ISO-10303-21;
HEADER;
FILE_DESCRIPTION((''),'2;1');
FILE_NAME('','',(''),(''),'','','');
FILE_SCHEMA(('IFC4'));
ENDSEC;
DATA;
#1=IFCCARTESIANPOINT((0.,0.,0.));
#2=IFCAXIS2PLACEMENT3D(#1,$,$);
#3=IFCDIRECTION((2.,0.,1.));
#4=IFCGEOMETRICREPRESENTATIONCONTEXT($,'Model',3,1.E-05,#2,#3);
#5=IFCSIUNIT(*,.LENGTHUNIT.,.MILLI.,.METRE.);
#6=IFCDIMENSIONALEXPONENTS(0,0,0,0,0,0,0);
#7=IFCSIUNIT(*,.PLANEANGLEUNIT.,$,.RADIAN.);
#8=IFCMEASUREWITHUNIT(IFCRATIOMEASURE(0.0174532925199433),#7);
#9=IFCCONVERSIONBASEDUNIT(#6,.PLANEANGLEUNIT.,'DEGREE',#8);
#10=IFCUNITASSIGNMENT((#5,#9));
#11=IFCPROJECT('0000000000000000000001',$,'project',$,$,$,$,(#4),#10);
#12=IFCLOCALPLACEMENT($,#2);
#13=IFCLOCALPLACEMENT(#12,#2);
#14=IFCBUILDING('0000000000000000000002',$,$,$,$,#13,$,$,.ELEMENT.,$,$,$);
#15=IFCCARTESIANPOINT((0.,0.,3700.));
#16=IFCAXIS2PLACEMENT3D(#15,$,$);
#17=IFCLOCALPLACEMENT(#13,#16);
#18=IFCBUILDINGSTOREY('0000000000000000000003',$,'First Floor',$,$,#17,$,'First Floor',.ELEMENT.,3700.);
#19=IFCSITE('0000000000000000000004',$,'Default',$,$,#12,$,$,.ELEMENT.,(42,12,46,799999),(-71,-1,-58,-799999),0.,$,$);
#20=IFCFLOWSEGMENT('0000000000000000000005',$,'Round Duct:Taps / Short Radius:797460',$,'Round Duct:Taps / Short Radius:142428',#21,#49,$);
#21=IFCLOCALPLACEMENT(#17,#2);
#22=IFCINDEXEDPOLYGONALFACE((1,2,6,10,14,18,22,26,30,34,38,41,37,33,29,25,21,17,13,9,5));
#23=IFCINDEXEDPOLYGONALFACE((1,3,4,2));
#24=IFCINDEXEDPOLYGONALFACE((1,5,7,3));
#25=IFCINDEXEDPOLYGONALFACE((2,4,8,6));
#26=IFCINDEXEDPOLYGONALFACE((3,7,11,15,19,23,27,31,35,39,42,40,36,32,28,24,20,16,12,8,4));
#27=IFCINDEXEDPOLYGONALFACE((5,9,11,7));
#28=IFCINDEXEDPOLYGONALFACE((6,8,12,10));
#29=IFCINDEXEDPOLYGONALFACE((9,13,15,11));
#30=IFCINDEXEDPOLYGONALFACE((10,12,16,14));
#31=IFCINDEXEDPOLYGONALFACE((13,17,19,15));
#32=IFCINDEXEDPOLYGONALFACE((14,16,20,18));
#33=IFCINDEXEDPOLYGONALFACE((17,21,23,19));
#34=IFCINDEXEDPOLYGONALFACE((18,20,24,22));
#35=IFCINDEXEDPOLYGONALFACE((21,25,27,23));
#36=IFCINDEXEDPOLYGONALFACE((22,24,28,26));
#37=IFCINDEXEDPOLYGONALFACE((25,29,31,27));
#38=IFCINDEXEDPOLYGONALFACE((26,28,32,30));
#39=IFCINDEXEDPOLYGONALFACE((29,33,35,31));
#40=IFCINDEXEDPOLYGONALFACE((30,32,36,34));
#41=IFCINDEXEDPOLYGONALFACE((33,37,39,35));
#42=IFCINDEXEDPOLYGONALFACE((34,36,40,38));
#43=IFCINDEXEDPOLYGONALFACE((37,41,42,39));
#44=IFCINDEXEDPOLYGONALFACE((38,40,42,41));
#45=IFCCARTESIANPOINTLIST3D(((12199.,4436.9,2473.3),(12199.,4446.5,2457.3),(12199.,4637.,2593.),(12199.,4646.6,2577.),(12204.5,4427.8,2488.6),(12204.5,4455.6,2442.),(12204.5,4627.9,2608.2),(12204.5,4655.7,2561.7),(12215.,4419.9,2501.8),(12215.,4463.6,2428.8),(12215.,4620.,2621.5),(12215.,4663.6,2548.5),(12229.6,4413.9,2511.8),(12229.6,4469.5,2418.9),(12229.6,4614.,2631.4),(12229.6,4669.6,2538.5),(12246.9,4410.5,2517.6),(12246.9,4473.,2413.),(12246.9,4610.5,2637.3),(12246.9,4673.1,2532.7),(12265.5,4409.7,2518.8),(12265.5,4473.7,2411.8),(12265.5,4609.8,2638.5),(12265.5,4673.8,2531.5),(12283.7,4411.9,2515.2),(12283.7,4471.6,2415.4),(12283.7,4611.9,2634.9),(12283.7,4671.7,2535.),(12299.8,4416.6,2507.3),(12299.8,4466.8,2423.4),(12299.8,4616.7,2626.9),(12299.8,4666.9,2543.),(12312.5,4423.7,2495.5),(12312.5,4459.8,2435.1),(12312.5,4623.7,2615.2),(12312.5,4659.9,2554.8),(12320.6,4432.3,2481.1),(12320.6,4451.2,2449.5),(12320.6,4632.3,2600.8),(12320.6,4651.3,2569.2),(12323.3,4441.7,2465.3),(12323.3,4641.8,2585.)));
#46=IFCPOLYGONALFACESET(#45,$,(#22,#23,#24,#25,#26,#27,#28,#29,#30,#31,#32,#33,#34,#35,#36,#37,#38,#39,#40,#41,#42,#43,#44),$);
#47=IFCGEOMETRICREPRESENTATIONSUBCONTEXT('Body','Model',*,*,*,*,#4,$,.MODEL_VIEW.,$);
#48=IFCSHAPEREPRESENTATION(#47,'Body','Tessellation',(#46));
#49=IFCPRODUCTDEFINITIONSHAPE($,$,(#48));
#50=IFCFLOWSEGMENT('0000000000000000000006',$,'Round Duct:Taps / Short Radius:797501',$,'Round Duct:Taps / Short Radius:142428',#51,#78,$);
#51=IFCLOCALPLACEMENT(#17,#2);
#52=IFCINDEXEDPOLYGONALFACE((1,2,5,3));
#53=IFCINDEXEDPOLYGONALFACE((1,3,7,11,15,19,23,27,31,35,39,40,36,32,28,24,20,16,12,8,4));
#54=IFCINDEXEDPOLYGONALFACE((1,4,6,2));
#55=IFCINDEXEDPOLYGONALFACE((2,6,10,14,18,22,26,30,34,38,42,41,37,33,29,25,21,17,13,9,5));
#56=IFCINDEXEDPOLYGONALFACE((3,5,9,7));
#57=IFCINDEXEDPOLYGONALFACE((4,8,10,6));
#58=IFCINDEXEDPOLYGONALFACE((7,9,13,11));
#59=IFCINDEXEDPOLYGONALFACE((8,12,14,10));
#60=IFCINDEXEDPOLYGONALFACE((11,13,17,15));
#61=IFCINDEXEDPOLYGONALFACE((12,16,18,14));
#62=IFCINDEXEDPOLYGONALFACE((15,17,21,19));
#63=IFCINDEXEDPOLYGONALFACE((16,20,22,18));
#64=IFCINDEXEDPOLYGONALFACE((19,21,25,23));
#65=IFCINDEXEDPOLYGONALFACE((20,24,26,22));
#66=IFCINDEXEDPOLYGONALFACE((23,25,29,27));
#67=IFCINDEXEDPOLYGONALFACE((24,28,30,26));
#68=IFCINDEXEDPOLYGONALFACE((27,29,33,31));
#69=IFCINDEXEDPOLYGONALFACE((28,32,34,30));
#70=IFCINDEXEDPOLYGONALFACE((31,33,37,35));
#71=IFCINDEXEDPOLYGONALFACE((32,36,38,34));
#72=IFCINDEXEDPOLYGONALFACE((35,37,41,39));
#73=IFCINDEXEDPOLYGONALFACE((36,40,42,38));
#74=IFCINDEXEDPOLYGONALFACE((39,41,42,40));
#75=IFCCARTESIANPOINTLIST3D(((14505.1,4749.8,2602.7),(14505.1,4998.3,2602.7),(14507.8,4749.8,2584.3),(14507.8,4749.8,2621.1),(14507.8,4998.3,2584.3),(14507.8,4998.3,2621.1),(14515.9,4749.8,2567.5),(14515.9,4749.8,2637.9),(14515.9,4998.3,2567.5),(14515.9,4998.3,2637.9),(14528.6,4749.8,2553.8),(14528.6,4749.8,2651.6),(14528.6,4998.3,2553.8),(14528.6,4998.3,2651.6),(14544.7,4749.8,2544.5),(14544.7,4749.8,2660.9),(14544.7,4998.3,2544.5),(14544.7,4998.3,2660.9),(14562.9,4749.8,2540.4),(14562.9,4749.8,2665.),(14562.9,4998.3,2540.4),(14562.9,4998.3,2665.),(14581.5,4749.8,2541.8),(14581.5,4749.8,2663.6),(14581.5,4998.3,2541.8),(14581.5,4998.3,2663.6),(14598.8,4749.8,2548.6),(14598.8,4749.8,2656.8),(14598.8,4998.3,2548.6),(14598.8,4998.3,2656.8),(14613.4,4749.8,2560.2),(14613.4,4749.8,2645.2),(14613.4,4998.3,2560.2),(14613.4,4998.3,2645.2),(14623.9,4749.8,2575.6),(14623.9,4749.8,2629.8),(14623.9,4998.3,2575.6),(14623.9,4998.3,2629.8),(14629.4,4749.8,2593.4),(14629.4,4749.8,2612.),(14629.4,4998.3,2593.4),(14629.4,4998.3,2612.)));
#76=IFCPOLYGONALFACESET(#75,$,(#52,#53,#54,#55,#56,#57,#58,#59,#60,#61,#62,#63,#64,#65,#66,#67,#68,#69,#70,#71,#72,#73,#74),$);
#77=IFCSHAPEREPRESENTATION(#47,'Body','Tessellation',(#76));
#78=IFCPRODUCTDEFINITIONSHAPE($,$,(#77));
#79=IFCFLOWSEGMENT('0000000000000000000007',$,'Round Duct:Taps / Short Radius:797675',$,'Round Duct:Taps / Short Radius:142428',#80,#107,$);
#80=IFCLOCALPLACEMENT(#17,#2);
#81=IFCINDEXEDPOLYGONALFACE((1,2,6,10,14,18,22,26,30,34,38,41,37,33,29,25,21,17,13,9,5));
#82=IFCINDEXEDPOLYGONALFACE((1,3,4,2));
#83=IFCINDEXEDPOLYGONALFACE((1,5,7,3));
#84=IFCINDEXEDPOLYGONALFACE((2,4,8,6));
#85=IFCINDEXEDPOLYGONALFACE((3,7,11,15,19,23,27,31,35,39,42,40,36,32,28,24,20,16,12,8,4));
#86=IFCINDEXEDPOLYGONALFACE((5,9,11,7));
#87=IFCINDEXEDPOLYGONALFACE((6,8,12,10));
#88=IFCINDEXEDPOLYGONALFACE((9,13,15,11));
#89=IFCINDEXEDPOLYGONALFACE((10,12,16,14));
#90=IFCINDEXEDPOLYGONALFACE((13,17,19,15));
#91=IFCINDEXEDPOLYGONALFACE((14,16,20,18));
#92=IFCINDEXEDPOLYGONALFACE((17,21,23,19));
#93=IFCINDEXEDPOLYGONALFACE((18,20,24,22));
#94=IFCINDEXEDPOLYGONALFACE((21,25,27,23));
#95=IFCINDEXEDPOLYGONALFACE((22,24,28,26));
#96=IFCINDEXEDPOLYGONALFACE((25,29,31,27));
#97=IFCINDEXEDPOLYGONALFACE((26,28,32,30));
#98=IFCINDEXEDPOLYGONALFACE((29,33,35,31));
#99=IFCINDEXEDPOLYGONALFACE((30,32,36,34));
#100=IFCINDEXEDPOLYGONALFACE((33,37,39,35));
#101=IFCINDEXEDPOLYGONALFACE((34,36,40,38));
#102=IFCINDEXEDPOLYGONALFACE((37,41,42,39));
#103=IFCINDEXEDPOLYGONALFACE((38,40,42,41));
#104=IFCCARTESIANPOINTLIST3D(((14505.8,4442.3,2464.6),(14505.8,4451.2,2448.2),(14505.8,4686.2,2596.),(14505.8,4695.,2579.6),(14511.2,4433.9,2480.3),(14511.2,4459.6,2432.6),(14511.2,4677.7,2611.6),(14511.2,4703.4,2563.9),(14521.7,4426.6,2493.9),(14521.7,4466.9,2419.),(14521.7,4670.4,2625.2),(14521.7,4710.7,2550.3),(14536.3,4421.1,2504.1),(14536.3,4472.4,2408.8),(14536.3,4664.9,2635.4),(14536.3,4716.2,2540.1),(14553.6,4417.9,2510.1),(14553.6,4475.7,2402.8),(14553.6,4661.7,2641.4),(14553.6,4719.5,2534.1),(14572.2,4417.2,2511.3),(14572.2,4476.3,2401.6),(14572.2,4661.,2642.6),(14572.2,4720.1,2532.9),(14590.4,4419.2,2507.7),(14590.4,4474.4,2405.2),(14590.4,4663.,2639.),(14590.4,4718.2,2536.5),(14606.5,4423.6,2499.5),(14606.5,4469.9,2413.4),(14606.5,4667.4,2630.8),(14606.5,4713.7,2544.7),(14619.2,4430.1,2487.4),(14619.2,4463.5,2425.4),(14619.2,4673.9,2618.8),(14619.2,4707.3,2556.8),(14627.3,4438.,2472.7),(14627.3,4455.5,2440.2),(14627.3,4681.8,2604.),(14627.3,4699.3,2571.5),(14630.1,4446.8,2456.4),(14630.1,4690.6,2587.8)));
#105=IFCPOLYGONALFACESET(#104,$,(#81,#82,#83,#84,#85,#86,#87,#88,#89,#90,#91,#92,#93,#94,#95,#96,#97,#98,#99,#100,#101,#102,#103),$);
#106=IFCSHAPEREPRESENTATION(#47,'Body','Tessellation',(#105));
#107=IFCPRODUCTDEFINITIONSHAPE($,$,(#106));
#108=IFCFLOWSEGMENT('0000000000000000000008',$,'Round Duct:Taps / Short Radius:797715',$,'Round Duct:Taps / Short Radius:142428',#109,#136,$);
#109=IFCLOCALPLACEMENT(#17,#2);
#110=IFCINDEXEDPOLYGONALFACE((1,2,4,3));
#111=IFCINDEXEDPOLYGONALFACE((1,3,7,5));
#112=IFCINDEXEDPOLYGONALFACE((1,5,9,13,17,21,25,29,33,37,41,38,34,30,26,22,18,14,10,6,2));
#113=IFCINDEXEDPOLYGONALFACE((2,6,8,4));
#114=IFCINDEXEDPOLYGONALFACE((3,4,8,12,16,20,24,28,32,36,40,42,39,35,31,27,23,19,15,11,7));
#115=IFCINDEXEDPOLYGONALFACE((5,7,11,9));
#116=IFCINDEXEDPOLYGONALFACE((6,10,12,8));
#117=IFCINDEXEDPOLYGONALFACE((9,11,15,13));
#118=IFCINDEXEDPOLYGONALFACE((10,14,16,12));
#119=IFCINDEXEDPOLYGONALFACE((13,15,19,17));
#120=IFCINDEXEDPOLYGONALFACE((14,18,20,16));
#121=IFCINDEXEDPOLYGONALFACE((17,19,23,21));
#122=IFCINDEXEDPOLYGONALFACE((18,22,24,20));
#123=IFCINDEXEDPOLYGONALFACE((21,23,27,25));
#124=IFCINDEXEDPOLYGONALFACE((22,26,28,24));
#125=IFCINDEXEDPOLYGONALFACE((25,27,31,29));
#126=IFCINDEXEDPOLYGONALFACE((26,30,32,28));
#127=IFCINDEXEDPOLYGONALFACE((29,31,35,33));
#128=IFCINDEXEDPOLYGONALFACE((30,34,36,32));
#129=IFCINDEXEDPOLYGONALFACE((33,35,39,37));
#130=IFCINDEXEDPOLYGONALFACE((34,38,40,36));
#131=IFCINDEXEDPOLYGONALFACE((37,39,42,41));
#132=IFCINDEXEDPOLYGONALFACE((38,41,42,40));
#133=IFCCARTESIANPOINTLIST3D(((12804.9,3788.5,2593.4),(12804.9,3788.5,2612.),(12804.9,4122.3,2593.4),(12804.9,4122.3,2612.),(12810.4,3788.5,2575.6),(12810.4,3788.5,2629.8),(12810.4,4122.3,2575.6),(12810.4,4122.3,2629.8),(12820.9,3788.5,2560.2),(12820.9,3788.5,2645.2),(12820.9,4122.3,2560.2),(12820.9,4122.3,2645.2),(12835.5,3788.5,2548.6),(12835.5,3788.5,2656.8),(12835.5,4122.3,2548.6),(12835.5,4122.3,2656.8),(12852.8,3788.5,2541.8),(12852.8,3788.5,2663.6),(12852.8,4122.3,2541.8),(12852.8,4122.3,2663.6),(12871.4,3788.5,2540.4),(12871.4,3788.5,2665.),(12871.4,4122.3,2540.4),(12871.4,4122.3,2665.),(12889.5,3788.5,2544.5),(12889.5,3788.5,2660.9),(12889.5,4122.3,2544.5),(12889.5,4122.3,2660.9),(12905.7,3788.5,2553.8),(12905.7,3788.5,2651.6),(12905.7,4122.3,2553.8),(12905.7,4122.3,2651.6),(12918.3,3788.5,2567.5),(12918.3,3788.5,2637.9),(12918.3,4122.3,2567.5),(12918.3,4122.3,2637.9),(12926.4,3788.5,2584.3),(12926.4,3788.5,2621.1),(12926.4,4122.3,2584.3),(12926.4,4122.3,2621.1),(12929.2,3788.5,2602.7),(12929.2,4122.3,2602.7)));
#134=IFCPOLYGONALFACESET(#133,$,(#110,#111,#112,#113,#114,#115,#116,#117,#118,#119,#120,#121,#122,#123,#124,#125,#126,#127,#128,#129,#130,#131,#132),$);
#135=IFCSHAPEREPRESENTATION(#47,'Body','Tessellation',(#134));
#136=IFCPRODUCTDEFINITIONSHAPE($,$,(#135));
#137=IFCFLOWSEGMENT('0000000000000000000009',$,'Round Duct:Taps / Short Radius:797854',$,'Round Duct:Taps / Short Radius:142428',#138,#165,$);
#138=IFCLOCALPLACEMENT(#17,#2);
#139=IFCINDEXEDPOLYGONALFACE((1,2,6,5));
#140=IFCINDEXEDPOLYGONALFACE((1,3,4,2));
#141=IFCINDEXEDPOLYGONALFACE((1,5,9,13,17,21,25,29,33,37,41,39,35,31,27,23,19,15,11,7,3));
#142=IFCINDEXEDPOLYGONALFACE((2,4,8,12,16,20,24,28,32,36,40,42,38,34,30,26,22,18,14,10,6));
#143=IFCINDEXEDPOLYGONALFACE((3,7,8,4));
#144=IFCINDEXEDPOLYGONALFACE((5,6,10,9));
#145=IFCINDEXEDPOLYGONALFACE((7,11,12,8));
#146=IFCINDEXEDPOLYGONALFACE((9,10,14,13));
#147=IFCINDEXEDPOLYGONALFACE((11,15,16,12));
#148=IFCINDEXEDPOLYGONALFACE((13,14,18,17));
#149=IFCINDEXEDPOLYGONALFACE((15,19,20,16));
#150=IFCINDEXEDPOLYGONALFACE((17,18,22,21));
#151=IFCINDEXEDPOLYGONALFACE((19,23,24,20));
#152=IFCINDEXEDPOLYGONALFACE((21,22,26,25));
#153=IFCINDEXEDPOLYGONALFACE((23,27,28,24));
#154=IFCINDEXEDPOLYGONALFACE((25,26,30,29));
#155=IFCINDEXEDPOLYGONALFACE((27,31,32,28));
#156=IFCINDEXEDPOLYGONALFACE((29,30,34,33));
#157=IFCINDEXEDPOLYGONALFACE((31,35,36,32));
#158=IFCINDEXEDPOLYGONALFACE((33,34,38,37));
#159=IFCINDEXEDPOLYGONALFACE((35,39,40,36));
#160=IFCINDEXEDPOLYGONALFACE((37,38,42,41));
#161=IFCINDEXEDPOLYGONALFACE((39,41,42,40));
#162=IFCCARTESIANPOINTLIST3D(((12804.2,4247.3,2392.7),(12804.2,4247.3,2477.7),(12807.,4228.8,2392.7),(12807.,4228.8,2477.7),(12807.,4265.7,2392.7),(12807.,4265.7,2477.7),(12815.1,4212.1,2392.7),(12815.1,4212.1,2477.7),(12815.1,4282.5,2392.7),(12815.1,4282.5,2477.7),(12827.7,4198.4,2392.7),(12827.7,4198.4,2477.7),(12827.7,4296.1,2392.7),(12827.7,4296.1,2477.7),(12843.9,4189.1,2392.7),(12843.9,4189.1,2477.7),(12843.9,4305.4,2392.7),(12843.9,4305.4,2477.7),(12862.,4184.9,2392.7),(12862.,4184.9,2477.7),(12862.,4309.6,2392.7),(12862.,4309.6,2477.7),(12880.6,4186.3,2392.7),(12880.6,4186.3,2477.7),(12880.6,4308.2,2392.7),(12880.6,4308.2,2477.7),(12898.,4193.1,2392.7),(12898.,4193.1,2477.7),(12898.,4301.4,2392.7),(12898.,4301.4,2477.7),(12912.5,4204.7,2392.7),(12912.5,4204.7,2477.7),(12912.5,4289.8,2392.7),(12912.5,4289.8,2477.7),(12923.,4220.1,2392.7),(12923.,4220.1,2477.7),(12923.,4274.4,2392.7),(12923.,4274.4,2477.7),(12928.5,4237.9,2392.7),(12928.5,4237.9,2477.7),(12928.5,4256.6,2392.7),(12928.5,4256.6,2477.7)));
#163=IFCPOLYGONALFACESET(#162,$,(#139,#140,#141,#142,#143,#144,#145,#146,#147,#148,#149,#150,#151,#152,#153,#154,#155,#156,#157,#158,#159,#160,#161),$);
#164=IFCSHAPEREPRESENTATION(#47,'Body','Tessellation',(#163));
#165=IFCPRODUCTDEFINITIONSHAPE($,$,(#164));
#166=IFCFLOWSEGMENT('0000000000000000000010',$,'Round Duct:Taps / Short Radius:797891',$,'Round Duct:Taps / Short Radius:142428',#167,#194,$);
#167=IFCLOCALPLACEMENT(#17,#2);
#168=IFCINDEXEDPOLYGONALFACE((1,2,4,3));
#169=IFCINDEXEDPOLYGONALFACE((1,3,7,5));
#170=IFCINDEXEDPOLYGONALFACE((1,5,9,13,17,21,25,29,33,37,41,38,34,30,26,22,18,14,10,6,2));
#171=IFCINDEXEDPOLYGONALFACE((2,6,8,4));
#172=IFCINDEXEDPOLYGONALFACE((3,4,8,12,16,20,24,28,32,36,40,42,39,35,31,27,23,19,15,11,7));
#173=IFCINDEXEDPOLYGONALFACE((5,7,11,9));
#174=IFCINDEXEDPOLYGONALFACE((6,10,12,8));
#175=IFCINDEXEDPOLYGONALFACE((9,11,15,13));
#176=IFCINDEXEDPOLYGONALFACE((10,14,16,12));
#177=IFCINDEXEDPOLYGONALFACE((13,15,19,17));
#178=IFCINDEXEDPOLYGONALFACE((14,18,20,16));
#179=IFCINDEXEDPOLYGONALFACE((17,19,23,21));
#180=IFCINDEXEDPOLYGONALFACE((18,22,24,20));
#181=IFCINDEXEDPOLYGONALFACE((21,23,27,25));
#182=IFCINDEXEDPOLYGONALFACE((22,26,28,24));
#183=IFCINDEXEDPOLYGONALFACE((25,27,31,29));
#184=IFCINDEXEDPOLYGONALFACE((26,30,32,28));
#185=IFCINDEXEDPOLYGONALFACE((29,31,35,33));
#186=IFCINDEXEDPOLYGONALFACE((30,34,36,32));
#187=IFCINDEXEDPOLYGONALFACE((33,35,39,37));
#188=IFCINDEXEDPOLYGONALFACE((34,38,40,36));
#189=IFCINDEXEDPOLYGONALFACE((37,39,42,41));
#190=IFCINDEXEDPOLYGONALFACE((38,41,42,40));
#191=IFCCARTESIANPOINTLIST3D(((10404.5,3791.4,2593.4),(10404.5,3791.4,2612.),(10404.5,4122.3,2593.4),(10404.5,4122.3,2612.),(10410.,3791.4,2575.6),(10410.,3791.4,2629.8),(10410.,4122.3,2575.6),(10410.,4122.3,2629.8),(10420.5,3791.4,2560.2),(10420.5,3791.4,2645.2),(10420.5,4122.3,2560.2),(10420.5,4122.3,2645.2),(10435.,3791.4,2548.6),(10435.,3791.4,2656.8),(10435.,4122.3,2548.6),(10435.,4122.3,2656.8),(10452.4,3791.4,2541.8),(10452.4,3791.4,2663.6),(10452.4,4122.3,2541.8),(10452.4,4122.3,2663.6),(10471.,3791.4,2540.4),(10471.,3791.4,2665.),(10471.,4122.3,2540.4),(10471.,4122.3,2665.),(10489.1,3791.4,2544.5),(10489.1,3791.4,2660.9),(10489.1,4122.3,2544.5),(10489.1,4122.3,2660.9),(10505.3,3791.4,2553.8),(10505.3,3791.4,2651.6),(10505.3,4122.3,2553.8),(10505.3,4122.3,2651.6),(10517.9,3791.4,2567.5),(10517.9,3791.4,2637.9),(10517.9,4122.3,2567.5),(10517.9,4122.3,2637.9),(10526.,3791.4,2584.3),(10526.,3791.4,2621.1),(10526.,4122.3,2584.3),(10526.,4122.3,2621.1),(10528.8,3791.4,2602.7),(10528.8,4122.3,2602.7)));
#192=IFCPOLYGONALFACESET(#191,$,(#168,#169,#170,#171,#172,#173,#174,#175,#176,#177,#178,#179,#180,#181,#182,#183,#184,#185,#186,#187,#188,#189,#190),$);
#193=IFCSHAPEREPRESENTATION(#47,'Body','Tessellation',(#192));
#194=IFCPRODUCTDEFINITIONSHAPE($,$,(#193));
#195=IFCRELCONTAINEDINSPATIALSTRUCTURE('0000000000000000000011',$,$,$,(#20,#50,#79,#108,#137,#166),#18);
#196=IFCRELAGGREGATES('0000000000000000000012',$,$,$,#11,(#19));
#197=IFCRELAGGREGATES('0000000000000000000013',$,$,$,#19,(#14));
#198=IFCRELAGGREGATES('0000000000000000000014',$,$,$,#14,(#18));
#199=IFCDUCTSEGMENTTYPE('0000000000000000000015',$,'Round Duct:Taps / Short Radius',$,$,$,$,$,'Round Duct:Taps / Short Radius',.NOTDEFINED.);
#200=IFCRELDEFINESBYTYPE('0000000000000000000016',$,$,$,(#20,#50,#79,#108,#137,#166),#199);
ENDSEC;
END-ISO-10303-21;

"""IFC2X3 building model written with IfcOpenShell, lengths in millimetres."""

from ifc_helpers import new_model, entity, si_unit, converted_unit, direction, frame, frame_2d, origin, origin_2d_with_axis, place, context, subcontext, project, spatial, circle, extrude, type_object, element, save


model = new_model("IFC2X3")

# Units and contexts
model_context = context("Model", 3, precision=1e-05, world=origin(), true_north=direction((2.0, 0.0, 1.0)))
body_context = subcontext(model_context, "Body", "Model", "MODEL_VIEW")
ifc_project = project(units=[si_unit("LENGTHUNIT", "METRE", prefix="MILLI"), converted_unit("PLANEANGLEUNIT", "DEGREE", entity("IfcRatioMeasure", 0.0174532925199433), si_unit("PLANEANGLEUNIT", "RADIAN"), dimensions=[0, 0, 0, 0, 0, 0, 0])], contexts=[model_context])

# Site, building, storey
site_placement = place(None, origin())
site = spatial("IfcSite", under=ifc_project, at=site_placement, Name="Default", CompositionType="ELEMENT", RefLatitude=(42, 12, 46, 799999), RefLongitude=(-71, -1, -58, -799999), RefElevation=0.0)
building_placement = place(site_placement, origin())
building = spatial("IfcBuilding", under=site, at=building_placement, CompositionType="ELEMENT")
storey_placement = place(building_placement, frame((0.0, 0.0, 3700.0)))
storey = spatial("IfcBuildingStorey", under=building, at=storey_placement, Name="First Floor", LongName="First Floor", CompositionType="ELEMENT", Elevation=3700.0)

# Flow segments
duct_segment_type = type_object("IfcDuctSegmentType", Name="Round Duct:Taps / Short Radius", ElementType="Round Duct:Taps / Short Radius", PredefinedType="NOTDEFINED")
flow_segment_1_placement = place(storey_placement, origin())
element("IfcFlowSegment", 1, at=flow_segment_1_placement, inside=storey, type_object=duct_segment_type, Name="Round Duct:Taps / Short Radius:797460", ObjectType="Round Duct:Taps / Short Radius:142428", context=body_context, shape_type="SweptSolid", body=[
    extrude(circle(Radius=62.5, at=frame_2d((0.0, 0.0), x_axis=(1.0, 0.0))), frame((12260.8, 4441.7, 2465.3), z_axis=(0.0, 0.858207, 0.513304), x_axis=(1.0, 0.0, 0.0)), (0.0, 0.0, 1.0), 233.1),
])
flow_segment_2_placement = place(storey_placement, origin())
element("IfcFlowSegment", 2, at=flow_segment_2_placement, inside=storey, type_object=duct_segment_type, Name="Round Duct:Taps / Short Radius:797501", ObjectType="Round Duct:Taps / Short Radius:142428", context=body_context, shape_type="SweptSolid", body=[
    extrude(circle(Radius=62.5, at=frame_2d((0.0, 0.0), x_axis=(1.0, 0.0))), frame((14567.6, 4749.8, 2602.7), z_axis=(0.0, 1.0, 0.0), x_axis=(-1.0, 0.0, 0.0)), (0.0, 0.0, 1.0), 248.5),
])
flow_segment_3_placement = place(storey_placement, origin())
element("IfcFlowSegment", 3, at=flow_segment_3_placement, inside=storey, type_object=duct_segment_type, Name="Round Duct:Taps / Short Radius:797675", ObjectType="Round Duct:Taps / Short Radius:142428", context=body_context, shape_type="SweptSolid", body=[
    extrude(circle(Radius=62.5, at=frame_2d((0.0, 0.0), x_axis=(1.0, 0.0))), frame((14567.6, 4446.8, 2456.4), z_axis=(0.0, 0.880434, 0.474169), x_axis=(1.0, 0.0, 0.0)), (0.0, 0.0, 1.0), 276.9),
])
flow_segment_4_placement = place(storey_placement, origin())
element("IfcFlowSegment", 4, at=flow_segment_4_placement, inside=storey, type_object=duct_segment_type, Name="Round Duct:Taps / Short Radius:797715", ObjectType="Round Duct:Taps / Short Radius:142428", context=body_context, shape_type="SweptSolid", body=[
    extrude(circle(Radius=62.5, at=origin_2d_with_axis()), frame((12866.7, 3788.5, 2602.7), z_axis=(0.0, 1.0, 0.0), x_axis=(1.0, 0.0, 0.0)), (0.0, 0.0, 1.0), 333.7),
])
flow_segment_5_placement = place(storey_placement, origin())
element("IfcFlowSegment", 5, at=flow_segment_5_placement, inside=storey, type_object=duct_segment_type, Name="Round Duct:Taps / Short Radius:797854", ObjectType="Round Duct:Taps / Short Radius:142428", context=body_context, shape_type="SweptSolid", body=[
    extrude(circle(Radius=62.5, at=frame_2d((0.0, 0.0), x_axis=(1.0, 0.0))), frame((12866.7, 4247.3, 2392.7), z_axis=(0.0, 0.0, 1.0), x_axis=(-1.0, 0.0, 0.0)), (0.0, 0.0, 1.0), 85.0),
])
flow_segment_6_placement = place(storey_placement, origin())
element("IfcFlowSegment", 6, at=flow_segment_6_placement, inside=storey, type_object=duct_segment_type, Name="Round Duct:Taps / Short Radius:797891", ObjectType="Round Duct:Taps / Short Radius:142428", context=body_context, shape_type="SweptSolid", body=[
    extrude(circle(Radius=62.5, at=origin_2d_with_axis()), frame((10466.3, 3791.4, 2602.7), z_axis=(0.0, 1.0, 0.0), x_axis=(1.0, 0.0, 0.0)), (0.0, 0.0, 1.0), 330.8),
])

save(model, "model.ifc")
